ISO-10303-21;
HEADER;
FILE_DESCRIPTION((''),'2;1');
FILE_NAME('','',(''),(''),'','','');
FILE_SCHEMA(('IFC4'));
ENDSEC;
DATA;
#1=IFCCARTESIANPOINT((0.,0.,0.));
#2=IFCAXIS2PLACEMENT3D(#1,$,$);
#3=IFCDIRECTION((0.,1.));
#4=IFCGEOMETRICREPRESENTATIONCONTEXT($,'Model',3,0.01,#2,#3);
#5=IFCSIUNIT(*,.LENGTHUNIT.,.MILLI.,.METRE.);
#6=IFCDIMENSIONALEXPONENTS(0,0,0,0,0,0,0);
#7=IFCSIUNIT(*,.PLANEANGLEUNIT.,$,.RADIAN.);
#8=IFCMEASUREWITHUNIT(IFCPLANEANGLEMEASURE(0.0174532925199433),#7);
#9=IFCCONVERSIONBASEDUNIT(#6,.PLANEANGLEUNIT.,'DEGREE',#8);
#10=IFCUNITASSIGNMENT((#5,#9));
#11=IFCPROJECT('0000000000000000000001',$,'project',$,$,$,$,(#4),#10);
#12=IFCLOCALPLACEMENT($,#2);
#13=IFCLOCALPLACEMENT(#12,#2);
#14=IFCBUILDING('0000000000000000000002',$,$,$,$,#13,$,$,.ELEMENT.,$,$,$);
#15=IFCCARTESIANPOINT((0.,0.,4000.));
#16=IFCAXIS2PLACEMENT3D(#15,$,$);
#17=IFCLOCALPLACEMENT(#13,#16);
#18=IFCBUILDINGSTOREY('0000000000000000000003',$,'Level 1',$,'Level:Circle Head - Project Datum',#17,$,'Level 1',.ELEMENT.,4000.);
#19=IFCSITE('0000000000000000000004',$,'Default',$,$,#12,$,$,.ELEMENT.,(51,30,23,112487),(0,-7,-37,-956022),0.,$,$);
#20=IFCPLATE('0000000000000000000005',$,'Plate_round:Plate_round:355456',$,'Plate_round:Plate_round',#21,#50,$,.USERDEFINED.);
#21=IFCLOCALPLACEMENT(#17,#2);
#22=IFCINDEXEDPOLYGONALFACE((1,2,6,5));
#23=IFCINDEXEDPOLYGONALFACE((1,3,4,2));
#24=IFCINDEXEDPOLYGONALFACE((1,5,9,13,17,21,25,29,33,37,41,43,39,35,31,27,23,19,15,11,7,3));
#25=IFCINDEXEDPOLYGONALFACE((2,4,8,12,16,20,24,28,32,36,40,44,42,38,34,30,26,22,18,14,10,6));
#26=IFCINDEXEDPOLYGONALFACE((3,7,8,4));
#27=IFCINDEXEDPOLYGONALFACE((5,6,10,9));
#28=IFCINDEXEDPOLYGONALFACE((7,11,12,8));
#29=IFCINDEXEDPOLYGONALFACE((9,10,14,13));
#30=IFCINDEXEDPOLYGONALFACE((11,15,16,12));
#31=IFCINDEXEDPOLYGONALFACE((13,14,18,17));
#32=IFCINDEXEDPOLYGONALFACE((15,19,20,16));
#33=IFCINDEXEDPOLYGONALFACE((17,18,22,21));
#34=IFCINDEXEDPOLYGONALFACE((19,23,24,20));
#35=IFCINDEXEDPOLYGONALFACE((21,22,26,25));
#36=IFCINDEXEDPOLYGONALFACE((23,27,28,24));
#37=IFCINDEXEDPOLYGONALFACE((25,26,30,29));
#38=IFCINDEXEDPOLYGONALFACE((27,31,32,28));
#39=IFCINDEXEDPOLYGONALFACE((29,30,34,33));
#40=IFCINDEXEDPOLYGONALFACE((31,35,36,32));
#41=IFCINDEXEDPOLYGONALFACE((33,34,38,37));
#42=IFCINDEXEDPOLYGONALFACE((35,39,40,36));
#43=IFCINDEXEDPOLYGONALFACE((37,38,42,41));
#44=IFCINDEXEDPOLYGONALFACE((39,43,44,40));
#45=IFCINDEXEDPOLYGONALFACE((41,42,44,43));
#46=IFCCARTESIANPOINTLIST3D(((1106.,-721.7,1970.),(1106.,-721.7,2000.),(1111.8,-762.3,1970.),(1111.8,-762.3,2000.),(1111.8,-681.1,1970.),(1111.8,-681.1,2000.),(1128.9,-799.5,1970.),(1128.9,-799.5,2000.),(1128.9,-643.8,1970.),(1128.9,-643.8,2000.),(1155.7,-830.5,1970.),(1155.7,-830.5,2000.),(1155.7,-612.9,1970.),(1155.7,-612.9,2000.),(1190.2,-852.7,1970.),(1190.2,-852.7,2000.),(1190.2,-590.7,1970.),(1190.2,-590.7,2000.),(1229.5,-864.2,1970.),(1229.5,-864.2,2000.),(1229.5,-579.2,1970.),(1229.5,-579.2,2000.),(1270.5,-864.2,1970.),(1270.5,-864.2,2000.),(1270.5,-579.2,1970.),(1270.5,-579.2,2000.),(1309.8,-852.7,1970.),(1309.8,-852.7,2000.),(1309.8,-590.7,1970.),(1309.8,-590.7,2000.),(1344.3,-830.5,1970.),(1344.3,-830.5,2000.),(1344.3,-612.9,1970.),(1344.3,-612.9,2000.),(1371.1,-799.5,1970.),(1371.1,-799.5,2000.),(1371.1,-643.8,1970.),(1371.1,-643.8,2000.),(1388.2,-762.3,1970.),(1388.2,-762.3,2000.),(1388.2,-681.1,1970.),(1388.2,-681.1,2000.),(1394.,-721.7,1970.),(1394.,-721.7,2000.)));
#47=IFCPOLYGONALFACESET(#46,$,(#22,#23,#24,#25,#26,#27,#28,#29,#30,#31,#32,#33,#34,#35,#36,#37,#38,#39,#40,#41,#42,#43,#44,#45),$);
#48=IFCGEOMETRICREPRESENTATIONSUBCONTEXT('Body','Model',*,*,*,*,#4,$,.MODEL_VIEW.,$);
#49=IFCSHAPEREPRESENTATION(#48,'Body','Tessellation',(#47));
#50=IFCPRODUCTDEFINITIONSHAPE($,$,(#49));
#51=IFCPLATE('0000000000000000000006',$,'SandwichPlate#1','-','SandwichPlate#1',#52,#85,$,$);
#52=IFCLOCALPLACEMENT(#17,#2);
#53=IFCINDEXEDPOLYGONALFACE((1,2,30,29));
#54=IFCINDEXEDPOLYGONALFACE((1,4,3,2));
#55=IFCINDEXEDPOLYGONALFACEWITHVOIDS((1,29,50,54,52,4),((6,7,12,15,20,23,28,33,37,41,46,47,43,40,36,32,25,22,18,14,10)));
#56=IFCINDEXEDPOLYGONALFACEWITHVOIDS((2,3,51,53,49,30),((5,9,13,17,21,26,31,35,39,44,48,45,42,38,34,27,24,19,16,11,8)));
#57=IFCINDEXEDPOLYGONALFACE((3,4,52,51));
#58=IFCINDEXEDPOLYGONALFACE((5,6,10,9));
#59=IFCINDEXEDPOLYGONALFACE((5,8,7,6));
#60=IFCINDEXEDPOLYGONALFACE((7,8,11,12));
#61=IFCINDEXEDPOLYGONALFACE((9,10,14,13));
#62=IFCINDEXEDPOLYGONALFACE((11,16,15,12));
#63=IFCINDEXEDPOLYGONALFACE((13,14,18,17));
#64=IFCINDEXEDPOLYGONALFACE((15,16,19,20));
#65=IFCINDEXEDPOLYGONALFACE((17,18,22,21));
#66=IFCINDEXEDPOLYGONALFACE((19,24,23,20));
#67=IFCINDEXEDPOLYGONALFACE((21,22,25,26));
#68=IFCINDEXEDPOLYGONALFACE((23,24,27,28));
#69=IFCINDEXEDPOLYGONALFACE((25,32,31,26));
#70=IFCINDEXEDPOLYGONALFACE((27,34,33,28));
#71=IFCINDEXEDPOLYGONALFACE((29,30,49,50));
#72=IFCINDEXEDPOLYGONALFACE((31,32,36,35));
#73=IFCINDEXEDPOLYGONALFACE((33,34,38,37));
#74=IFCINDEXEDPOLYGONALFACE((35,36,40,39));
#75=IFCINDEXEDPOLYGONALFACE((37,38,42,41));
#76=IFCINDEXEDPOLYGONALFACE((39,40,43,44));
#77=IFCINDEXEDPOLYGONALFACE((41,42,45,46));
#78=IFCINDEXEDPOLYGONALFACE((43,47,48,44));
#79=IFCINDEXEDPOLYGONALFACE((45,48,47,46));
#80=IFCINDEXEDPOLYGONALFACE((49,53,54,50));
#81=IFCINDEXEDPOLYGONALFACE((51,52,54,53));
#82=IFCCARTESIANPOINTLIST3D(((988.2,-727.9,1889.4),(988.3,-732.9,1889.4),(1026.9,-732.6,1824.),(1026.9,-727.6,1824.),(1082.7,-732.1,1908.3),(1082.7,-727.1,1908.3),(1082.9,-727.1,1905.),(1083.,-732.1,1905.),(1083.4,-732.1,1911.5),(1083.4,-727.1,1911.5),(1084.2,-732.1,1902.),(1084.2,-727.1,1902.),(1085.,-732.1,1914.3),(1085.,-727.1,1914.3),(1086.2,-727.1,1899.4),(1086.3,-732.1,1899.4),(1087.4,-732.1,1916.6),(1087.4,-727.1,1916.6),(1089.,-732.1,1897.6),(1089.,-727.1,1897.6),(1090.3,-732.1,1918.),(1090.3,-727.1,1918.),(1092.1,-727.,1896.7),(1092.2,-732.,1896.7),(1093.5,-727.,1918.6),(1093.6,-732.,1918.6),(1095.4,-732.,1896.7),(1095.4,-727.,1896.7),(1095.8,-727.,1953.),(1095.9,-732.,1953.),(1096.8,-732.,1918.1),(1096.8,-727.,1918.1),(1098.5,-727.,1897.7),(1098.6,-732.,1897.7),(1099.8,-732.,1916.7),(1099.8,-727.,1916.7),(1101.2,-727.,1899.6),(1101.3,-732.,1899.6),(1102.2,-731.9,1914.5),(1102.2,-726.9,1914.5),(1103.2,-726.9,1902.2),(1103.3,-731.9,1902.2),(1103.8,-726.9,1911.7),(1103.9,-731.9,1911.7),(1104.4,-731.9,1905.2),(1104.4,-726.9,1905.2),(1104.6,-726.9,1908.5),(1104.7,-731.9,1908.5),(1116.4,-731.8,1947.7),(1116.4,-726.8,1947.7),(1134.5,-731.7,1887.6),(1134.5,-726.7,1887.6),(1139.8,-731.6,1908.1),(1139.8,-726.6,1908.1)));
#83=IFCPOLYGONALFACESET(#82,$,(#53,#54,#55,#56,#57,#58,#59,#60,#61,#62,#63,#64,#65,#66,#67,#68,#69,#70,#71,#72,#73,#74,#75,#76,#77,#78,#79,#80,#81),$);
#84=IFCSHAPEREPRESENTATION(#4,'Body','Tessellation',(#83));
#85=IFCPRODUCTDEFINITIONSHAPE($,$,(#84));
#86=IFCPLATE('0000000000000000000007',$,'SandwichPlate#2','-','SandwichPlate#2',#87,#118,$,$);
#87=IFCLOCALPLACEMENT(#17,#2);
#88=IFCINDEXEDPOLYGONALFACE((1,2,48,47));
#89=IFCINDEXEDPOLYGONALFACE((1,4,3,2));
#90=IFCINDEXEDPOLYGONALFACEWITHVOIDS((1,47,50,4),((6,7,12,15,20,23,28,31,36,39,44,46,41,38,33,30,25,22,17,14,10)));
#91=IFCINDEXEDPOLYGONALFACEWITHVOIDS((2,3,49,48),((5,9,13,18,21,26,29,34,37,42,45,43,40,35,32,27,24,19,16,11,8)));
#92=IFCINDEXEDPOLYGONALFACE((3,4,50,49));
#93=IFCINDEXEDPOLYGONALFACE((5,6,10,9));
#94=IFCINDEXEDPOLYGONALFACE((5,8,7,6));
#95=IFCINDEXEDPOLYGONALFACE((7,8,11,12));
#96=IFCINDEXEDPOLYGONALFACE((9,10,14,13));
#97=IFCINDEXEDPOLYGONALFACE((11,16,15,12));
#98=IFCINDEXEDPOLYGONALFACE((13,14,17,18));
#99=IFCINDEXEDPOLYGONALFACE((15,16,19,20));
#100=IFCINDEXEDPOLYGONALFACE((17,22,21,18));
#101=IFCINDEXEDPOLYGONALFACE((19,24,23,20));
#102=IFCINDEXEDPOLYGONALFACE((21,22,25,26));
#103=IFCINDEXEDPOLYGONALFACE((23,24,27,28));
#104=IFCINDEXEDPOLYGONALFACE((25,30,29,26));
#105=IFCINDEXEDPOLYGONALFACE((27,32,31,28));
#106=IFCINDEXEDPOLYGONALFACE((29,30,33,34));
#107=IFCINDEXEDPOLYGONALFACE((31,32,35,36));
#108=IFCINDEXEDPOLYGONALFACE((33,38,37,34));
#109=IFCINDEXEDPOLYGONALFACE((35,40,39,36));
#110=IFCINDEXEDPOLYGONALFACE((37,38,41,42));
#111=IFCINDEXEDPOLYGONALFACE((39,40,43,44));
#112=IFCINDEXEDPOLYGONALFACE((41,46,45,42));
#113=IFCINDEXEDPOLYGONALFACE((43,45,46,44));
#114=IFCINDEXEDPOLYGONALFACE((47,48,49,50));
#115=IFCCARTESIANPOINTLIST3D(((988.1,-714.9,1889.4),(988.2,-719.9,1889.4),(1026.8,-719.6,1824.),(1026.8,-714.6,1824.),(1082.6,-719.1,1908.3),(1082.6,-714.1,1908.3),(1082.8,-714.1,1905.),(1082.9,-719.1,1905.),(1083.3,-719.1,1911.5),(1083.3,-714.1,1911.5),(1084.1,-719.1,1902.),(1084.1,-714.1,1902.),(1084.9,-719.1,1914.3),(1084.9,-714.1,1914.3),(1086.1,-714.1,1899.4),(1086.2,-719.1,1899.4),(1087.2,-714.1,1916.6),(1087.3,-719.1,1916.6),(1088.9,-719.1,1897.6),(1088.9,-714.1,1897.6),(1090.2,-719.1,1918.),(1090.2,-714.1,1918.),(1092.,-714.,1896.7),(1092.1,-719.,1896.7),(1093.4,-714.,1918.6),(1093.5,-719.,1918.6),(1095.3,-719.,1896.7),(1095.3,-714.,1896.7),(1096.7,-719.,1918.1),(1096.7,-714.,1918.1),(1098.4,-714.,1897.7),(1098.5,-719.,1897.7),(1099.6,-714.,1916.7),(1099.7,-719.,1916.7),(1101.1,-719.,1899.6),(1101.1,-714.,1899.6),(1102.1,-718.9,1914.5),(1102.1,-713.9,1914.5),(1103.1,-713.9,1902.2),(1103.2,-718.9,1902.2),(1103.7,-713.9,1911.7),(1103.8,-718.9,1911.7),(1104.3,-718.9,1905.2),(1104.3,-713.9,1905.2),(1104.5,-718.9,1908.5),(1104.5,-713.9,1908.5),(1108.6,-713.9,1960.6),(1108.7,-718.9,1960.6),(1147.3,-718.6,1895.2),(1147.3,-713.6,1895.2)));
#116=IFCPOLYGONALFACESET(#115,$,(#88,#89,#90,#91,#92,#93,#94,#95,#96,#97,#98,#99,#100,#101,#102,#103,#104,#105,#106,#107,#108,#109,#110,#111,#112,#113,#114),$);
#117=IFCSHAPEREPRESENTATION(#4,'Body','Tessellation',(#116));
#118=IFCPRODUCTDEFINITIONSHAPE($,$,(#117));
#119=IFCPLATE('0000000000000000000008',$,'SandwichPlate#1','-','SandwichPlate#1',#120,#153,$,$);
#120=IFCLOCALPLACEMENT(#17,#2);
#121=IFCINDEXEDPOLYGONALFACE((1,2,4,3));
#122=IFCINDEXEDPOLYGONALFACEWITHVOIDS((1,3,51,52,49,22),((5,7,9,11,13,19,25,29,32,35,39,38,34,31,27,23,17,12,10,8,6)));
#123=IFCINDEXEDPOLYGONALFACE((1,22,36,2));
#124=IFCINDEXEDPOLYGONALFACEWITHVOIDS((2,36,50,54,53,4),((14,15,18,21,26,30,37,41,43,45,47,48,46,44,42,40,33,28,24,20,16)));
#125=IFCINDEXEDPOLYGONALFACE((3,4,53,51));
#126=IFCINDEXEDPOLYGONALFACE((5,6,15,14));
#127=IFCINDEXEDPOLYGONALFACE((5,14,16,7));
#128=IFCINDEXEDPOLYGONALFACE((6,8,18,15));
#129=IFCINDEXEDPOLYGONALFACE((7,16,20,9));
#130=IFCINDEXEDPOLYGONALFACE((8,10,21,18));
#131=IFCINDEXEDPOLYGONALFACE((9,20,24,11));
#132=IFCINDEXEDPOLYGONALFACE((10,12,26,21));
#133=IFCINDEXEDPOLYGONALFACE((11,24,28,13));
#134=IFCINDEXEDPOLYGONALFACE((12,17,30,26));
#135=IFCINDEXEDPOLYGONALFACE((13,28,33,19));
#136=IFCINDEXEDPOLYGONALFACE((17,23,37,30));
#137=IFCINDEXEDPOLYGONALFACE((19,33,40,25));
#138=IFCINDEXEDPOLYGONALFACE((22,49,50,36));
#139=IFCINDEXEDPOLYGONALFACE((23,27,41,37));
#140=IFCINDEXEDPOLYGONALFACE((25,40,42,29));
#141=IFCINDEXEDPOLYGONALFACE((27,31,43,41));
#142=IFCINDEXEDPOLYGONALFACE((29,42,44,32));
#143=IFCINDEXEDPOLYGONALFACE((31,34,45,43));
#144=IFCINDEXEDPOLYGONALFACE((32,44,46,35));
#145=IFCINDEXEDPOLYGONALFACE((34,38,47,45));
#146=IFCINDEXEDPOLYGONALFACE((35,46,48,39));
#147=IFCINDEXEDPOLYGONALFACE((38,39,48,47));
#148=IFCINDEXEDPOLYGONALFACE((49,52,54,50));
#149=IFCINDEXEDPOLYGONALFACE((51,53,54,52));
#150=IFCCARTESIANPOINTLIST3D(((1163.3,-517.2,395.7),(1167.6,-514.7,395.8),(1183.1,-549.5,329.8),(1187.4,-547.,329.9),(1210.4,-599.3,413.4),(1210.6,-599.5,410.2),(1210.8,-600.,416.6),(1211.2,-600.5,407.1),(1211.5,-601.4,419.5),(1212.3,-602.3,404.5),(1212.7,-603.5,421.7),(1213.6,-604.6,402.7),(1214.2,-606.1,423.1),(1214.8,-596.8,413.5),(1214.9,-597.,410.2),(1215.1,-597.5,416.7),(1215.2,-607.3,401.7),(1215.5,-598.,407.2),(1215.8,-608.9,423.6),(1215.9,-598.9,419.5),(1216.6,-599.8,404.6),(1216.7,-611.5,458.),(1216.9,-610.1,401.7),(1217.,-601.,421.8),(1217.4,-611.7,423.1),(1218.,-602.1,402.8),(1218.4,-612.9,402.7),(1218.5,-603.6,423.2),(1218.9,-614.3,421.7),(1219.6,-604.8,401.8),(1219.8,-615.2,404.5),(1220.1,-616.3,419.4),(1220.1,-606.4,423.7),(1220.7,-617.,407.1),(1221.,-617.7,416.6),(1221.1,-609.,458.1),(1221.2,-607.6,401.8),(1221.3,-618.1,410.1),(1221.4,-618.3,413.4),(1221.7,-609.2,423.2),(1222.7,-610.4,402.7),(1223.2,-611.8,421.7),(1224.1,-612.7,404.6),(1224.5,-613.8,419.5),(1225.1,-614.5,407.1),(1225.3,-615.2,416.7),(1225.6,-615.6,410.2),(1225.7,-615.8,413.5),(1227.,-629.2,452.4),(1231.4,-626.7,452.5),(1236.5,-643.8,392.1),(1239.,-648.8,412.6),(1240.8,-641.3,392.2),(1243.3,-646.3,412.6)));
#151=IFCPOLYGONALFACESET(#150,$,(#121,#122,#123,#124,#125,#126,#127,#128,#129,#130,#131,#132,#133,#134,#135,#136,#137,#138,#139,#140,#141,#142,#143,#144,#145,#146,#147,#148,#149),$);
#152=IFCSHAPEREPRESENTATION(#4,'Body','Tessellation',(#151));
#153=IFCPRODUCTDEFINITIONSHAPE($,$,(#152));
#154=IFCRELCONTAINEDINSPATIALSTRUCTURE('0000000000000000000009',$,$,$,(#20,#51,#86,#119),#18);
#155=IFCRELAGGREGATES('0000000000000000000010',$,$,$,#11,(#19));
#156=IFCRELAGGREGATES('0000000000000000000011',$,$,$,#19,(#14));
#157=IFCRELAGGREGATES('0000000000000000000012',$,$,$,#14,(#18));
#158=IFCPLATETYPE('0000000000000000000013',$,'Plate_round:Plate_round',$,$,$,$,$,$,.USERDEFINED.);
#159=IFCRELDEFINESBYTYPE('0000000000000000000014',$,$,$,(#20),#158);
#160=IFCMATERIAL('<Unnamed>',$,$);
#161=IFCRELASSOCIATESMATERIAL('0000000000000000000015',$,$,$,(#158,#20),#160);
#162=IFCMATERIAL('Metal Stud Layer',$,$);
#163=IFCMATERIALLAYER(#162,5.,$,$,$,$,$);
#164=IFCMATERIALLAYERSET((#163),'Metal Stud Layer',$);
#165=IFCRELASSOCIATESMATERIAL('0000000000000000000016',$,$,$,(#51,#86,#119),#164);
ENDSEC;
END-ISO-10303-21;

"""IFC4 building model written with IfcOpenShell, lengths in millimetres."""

from ifc_helpers import new_model, entity, si_unit, converted_unit, direction, frame, origin, origin_with_axes, origin_2d_with_axis, place, context, subcontext, project, spatial, polyline, arc, indexed_curve, circle, outline, extrude, source, transform, mapped, material, layer, layer_set, type_object, type_shapes, element, save


model = new_model("IFC4")

# Units and contexts
model_context = context("Model", 3, precision=0.01, world=origin(), true_north=direction((0.0, 1.0)))
body_context = subcontext(model_context, "Body", "Model", "MODEL_VIEW")
ifc_project = project(units=[si_unit("LENGTHUNIT", "METRE", prefix="MILLI"), converted_unit("PLANEANGLEUNIT", "DEGREE", entity("IfcPlaneAngleMeasure", 0.0174532925199433), si_unit("PLANEANGLEUNIT", "RADIAN"), dimensions=[0, 0, 0, 0, 0, 0, 0])], contexts=[model_context])

# Site, building, storey
site_placement = place(None, origin())
site = spatial("IfcSite", under=ifc_project, at=site_placement, Name="Default", CompositionType="ELEMENT", RefLatitude=(51, 30, 23, 112487), RefLongitude=(0, -7, -37, -956022), RefElevation=0.0)
building_placement = place(site_placement, origin())
building = spatial("IfcBuilding", under=site, at=building_placement, CompositionType="ELEMENT")
storey_placement = place(building_placement, frame((0.0, 0.0, 4000.0)))
storey = spatial("IfcBuildingStorey", under=building, at=storey_placement, Name="Level 1", ObjectType="Level:Circle Head - Project Datum", LongName="Level 1", CompositionType="ELEMENT", Elevation=4000.0)

# Plate
ifc_material_1 = material(Name="<Unnamed>")
plate_type = type_object("IfcPlateType", Name="Plate_round:Plate_round", PredefinedType="USERDEFINED", material=ifc_material_1)
shared_shape = source(origin(), body_context, "Body", "SweptSolid", [
    extrude(outline(indexed_curve([(-144.0, 0.0), (0.0, -144.0), (144.0, 0.0), (0.0, 144.0)], segments=[arc(1, 2, 3), arc(3, 4, 1)], self_intersect=False)), origin(), (0.0, 0.0, 1.0), 30.0),
])
type_shapes(plate_type, [shared_shape])
plate_1_placement = place(storey_placement, frame((1250.0, -721.7, 1970.0)))
element("IfcPlate", 1, at=plate_1_placement, inside=storey, type_object=plate_type, material=ifc_material_1, Name="Plate_round:Plate_round:355456", ObjectType="Plate_round:Plate_round", PredefinedType="USERDEFINED", context=body_context, shape_type="MappedRepresentation", body=[
    mapped(shared_shape, transform((0.0, 0.0, 0.0), scale=1.0)),
])

# Shared definitions
ifc_material_2 = material(Name="Metal Stud Layer")

# Plates, openings
ifc_layer_1 = layer(ifc_material_2, 5.0)
ifc_layer_set_1 = layer_set([ifc_layer_1], Name="Metal Stud Layer")
plate_2_placement = place(storey_placement, frame((1108.8, -731.9, 1960.6), z_axis=(-0.008532, 0.999964, 0.0), x_axis=(0.50884, 0.004342, -0.86085)))
plate_2 = element("IfcPlate", 2, at=plate_2_placement, inside=storey, material=ifc_layer_set_1, Name="SandwichPlate#1", Description="-", ObjectType="SandwichPlate#1", context=model_context, shape_type="SweptSolid", body=[
    extrude(outline(polyline([(15.0, 0.0), (61.0, 0.0), (76.0, 15.0), (76.0, 140.0), (0.0, 140.0), (0.0, 15.0), (15.0, 0.0)])), origin_with_axes(), (0.0, 0.0, 1.0), 5.0),
])
opening_1_placement = place(plate_2_placement, frame((38.0, 40.0, -0.5), z_axis=(0.0, 0.0, 1.0), x_axis=(0.0, 1.0, 0.0)))
element("IfcOpeningElement", 3, at=opening_1_placement, cuts=plate_2, ObjectType="Opening", context=model_context, shape_type="SweptSolid", body=[
    extrude(circle(Radius=11.0, at=origin_2d_with_axis()), origin(), (0.0, 0.0, 1.0), 6.0),
])
plate_3_placement = place(storey_placement, frame((1108.7, -718.9, 1960.6), z_axis=(-0.008532, 0.999964, 0.0), x_axis=(0.50884, 0.004342, -0.86085)))
plate_3 = element("IfcPlate", 4, at=plate_3_placement, inside=storey, material=ifc_layer_set_1, Name="SandwichPlate#2", Description="-", ObjectType="SandwichPlate#2", context=model_context, shape_type="SweptSolid", body=[
    extrude(outline(polyline([(0.0, 0.0), (76.0, 0.0), (76.0, 140.0), (0.0, 140.0), (0.0, 0.0)])), origin_with_axes(), (0.0, 0.0, 1.0), 5.0),
])
opening_2_placement = place(plate_3_placement, frame((38.0, 40.0, -0.5), z_axis=(0.0, 0.0, 1.0), x_axis=(0.0, 1.0, 0.0)))
element("IfcOpeningElement", 5, at=opening_2_placement, cuts=plate_3, ObjectType="Opening", context=model_context, shape_type="SweptSolid", body=[
    extrude(circle(Radius=11.0, at=origin_2d_with_axis()), origin(), (0.0, 0.0, 1.0), 6.0),
])

# Plate, openings
plate_4_placement = place(storey_placement, frame((1247.2, -652.7, 399.6), z_axis=(-0.865935, -0.499948, -0.014432), x_axis=(-0.259821, 0.424992, 0.867107)))
plate_4 = element("IfcPlate", 6, at=plate_4_placement, inside=storey, material=ifc_layer_set_1, Name="SandwichPlate#1", Description="-", ObjectType="SandwichPlate#1", context=model_context, shape_type="SweptSolid", body=[
    extrude(outline(polyline([(0.0, 0.0), (76.0, 0.0), (76.0, 140.0), (0.0, 140.0), (0.0, 0.0)])), origin_with_axes(), (0.0, 0.0, 1.0), 5.0),
])
opening_3_placement = place(plate_4_placement, frame((0.0, 0.0, 0.0), z_axis=(0.0, 0.0, 1.0), x_axis=(1.0, 0.0, 0.0)))
element("IfcOpeningElement", 7, at=opening_3_placement, cuts=plate_4, ObjectType="Opening", context=model_context, shape_type="SweptSolid", body=[
    extrude(outline(polyline([(0.0, 0.0), (15.0, 0.0), (0.0, 15.0), (0.0, 0.0)])), origin(), (0.0, 0.0, 1.0), 5.0),
])
opening_4_placement = place(plate_4_placement, frame((0.0, 0.0, 0.0), z_axis=(0.0, 0.0, 1.0), x_axis=(1.0, 0.0, 0.0)))
element("IfcOpeningElement", 8, at=opening_4_placement, cuts=plate_4, ObjectType="Opening", context=model_context, shape_type="SweptSolid", body=[
    extrude(outline(polyline([(76.0, 0.0), (76.0, 15.0), (61.0, 0.0), (76.0, 0.0)])), origin(), (0.0, 0.0, 1.0), 5.0),
])
opening_5_placement = place(plate_4_placement, frame((38.0, 40.0, -0.5), z_axis=(0.0, 0.0, 1.0), x_axis=(0.0, 1.0, 0.0)))
element("IfcOpeningElement", 9, at=opening_5_placement, cuts=plate_4, ObjectType="Opening", context=model_context, shape_type="SweptSolid", body=[
    extrude(circle(Radius=11.0, at=origin_2d_with_axis()), origin(), (0.0, 0.0, 1.0), 6.0),
])

save(model, "model.ifc")
